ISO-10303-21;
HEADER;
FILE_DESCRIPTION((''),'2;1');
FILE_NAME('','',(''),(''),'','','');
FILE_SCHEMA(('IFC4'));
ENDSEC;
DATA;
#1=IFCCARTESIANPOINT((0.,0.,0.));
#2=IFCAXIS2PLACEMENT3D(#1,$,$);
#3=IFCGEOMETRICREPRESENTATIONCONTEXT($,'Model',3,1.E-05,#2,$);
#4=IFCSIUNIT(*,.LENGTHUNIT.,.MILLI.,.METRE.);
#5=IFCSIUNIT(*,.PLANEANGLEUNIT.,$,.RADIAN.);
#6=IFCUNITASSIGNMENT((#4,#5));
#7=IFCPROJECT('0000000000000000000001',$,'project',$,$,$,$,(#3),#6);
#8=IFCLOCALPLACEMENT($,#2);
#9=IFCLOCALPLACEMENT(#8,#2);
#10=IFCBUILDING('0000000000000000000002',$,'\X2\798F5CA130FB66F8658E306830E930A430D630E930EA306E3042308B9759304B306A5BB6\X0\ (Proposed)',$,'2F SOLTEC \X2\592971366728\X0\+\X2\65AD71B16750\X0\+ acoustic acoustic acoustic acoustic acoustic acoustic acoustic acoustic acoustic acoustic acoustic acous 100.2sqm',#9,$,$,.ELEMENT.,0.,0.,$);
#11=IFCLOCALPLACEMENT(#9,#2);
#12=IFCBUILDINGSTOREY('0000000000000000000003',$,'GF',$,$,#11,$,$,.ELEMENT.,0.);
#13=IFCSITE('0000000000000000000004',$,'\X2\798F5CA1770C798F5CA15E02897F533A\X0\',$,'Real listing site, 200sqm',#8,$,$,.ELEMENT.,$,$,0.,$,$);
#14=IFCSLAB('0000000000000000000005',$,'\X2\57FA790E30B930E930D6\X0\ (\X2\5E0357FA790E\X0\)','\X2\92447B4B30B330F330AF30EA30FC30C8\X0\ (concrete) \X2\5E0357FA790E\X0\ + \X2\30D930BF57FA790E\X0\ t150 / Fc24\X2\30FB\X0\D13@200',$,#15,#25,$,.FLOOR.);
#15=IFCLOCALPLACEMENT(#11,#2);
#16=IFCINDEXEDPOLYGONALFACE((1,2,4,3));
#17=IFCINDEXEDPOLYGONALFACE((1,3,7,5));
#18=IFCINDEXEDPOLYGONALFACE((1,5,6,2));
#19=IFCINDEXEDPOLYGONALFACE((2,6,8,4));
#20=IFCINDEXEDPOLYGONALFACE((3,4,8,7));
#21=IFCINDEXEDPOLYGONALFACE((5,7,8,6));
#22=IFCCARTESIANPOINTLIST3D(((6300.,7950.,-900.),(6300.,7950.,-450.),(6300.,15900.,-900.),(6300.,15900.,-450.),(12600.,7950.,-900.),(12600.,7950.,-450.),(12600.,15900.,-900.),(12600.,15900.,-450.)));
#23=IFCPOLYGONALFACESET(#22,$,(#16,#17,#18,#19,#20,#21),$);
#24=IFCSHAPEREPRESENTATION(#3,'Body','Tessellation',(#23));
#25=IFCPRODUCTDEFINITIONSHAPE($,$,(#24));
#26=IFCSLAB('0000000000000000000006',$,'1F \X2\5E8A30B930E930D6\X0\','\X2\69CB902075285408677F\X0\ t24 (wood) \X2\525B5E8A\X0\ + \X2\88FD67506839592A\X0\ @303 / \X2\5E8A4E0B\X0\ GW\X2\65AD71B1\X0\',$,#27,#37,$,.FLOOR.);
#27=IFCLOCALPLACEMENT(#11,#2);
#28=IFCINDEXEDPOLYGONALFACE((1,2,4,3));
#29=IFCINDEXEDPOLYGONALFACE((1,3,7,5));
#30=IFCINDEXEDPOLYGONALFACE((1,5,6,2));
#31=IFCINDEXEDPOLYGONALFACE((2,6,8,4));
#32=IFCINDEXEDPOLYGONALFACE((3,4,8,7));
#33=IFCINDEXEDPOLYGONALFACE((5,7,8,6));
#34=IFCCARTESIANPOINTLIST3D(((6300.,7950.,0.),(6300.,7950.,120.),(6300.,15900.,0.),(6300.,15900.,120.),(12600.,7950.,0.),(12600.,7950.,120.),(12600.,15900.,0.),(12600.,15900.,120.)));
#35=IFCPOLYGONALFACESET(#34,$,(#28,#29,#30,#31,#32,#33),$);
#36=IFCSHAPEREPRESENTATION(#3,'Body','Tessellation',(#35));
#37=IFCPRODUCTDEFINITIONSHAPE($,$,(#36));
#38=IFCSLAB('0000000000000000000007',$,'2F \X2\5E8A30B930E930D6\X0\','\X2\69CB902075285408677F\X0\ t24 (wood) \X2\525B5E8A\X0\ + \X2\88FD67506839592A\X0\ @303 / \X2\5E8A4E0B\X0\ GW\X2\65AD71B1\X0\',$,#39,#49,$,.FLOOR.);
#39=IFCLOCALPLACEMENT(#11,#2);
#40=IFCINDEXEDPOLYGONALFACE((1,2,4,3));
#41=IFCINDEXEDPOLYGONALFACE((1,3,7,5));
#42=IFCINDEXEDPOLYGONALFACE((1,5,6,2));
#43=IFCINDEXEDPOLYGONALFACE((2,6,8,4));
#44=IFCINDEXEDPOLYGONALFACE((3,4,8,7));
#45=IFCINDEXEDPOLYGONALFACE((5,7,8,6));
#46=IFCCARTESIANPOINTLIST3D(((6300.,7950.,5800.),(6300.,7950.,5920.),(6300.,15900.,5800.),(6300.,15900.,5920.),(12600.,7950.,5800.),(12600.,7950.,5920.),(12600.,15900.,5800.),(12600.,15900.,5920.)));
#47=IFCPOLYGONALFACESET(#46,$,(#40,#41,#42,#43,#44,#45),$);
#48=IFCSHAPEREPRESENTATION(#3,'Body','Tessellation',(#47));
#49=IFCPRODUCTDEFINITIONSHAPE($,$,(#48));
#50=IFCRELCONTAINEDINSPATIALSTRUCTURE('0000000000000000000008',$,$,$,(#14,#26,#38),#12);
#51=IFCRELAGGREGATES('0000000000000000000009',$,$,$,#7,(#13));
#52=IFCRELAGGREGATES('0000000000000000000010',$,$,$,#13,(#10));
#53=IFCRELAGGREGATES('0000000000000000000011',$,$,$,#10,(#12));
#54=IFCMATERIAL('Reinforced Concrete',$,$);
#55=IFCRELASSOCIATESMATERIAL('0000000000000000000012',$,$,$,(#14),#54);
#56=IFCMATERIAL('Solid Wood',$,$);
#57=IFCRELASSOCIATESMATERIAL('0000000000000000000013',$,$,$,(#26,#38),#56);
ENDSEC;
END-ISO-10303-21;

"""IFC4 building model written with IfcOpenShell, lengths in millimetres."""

from ifc_helpers import new_model, si_unit, frame, frame_2d, origin, place, context, project, spatial, rectangle, extrude, material, element, save


model = new_model("IFC4")

# Units and contexts
model_context = context("Model", 3, precision=1e-05, world=origin())
ifc_project = project(units=[si_unit("LENGTHUNIT", "METRE", prefix="MILLI"), si_unit("PLANEANGLEUNIT", "RADIAN")], contexts=[model_context])

# Site, building, storey
site_placement = place(None, origin())
site = spatial("IfcSite", under=ifc_project, at=site_placement, Name="福岡県福岡市西区", ObjectType="Real listing site, 200sqm", CompositionType="ELEMENT", RefElevation=0.0)
building_placement = place(site_placement, origin())
building = spatial("IfcBuilding", under=site, at=building_placement, Name="福岡・書斎とライブラリのある静かな家 (Proposed)", ObjectType="2F SOLTEC 天然木+断熱材+ acoustic acoustic acoustic acoustic acoustic acoustic acoustic acoustic acoustic acoustic acoustic acous 100.2sqm", CompositionType="ELEMENT", ElevationOfRefHeight=0.0, ElevationOfTerrain=0.0)
storey_placement = place(building_placement, origin())
storey = spatial("IfcBuildingStorey", under=building, at=storey_placement, Name="GF", CompositionType="ELEMENT", Elevation=0.0)

# Shared definitions
ifc_material_1 = material(Name="Solid Wood")

# Slabs
ifc_material_2 = material(Name="Reinforced Concrete")
slab_1_placement = place(storey_placement, frame((3150.0, 3975.0, -450.0)))
element("IfcSlab", 1, at=slab_1_placement, inside=storey, material=ifc_material_2, Name="基礎スラブ (布基礎)", Description="鉄筋コンクリート (concrete) 布基礎 + ベタ基礎 t150 / Fc24・D13@200", PredefinedType="FLOOR", context=model_context, shape_type="SweptSolid", body=[
    extrude(rectangle(XDim=6300.0, YDim=7950.0, at=frame_2d((3150.0, 3975.0))), frame((3150.0, 3975.0, -450.0)), (0.0, 0.0, 1.0), 450.0),
])
slab_2_placement = place(storey_placement, frame((3150.0, 3975.0, 0.0)))
element("IfcSlab", 2, at=slab_2_placement, inside=storey, material=ifc_material_1, Name="1F 床スラブ", Description="構造用合板 t24 (wood) 剛床 + 製材根太 @303 / 床下 GW断熱", PredefinedType="FLOOR", context=model_context, shape_type="SweptSolid", body=[
    extrude(rectangle(XDim=6300.0, YDim=7950.0, at=frame_2d((3150.0, 3975.0))), frame((3150.0, 3975.0, 0.0)), (0.0, 0.0, 1.0), 120.0),
])
slab_3_placement = place(storey_placement, frame((3150.0, 3975.0, 2900.0)))
element("IfcSlab", 3, at=slab_3_placement, inside=storey, material=ifc_material_1, Name="2F 床スラブ", Description="構造用合板 t24 (wood) 剛床 + 製材根太 @303 / 床下 GW断熱", PredefinedType="FLOOR", context=model_context, shape_type="SweptSolid", body=[
    extrude(rectangle(XDim=6300.0, YDim=7950.0, at=frame_2d((3150.0, 3975.0))), frame((3150.0, 3975.0, 2900.0)), (0.0, 0.0, 1.0), 120.0),
])

save(model, "model.ifc")
